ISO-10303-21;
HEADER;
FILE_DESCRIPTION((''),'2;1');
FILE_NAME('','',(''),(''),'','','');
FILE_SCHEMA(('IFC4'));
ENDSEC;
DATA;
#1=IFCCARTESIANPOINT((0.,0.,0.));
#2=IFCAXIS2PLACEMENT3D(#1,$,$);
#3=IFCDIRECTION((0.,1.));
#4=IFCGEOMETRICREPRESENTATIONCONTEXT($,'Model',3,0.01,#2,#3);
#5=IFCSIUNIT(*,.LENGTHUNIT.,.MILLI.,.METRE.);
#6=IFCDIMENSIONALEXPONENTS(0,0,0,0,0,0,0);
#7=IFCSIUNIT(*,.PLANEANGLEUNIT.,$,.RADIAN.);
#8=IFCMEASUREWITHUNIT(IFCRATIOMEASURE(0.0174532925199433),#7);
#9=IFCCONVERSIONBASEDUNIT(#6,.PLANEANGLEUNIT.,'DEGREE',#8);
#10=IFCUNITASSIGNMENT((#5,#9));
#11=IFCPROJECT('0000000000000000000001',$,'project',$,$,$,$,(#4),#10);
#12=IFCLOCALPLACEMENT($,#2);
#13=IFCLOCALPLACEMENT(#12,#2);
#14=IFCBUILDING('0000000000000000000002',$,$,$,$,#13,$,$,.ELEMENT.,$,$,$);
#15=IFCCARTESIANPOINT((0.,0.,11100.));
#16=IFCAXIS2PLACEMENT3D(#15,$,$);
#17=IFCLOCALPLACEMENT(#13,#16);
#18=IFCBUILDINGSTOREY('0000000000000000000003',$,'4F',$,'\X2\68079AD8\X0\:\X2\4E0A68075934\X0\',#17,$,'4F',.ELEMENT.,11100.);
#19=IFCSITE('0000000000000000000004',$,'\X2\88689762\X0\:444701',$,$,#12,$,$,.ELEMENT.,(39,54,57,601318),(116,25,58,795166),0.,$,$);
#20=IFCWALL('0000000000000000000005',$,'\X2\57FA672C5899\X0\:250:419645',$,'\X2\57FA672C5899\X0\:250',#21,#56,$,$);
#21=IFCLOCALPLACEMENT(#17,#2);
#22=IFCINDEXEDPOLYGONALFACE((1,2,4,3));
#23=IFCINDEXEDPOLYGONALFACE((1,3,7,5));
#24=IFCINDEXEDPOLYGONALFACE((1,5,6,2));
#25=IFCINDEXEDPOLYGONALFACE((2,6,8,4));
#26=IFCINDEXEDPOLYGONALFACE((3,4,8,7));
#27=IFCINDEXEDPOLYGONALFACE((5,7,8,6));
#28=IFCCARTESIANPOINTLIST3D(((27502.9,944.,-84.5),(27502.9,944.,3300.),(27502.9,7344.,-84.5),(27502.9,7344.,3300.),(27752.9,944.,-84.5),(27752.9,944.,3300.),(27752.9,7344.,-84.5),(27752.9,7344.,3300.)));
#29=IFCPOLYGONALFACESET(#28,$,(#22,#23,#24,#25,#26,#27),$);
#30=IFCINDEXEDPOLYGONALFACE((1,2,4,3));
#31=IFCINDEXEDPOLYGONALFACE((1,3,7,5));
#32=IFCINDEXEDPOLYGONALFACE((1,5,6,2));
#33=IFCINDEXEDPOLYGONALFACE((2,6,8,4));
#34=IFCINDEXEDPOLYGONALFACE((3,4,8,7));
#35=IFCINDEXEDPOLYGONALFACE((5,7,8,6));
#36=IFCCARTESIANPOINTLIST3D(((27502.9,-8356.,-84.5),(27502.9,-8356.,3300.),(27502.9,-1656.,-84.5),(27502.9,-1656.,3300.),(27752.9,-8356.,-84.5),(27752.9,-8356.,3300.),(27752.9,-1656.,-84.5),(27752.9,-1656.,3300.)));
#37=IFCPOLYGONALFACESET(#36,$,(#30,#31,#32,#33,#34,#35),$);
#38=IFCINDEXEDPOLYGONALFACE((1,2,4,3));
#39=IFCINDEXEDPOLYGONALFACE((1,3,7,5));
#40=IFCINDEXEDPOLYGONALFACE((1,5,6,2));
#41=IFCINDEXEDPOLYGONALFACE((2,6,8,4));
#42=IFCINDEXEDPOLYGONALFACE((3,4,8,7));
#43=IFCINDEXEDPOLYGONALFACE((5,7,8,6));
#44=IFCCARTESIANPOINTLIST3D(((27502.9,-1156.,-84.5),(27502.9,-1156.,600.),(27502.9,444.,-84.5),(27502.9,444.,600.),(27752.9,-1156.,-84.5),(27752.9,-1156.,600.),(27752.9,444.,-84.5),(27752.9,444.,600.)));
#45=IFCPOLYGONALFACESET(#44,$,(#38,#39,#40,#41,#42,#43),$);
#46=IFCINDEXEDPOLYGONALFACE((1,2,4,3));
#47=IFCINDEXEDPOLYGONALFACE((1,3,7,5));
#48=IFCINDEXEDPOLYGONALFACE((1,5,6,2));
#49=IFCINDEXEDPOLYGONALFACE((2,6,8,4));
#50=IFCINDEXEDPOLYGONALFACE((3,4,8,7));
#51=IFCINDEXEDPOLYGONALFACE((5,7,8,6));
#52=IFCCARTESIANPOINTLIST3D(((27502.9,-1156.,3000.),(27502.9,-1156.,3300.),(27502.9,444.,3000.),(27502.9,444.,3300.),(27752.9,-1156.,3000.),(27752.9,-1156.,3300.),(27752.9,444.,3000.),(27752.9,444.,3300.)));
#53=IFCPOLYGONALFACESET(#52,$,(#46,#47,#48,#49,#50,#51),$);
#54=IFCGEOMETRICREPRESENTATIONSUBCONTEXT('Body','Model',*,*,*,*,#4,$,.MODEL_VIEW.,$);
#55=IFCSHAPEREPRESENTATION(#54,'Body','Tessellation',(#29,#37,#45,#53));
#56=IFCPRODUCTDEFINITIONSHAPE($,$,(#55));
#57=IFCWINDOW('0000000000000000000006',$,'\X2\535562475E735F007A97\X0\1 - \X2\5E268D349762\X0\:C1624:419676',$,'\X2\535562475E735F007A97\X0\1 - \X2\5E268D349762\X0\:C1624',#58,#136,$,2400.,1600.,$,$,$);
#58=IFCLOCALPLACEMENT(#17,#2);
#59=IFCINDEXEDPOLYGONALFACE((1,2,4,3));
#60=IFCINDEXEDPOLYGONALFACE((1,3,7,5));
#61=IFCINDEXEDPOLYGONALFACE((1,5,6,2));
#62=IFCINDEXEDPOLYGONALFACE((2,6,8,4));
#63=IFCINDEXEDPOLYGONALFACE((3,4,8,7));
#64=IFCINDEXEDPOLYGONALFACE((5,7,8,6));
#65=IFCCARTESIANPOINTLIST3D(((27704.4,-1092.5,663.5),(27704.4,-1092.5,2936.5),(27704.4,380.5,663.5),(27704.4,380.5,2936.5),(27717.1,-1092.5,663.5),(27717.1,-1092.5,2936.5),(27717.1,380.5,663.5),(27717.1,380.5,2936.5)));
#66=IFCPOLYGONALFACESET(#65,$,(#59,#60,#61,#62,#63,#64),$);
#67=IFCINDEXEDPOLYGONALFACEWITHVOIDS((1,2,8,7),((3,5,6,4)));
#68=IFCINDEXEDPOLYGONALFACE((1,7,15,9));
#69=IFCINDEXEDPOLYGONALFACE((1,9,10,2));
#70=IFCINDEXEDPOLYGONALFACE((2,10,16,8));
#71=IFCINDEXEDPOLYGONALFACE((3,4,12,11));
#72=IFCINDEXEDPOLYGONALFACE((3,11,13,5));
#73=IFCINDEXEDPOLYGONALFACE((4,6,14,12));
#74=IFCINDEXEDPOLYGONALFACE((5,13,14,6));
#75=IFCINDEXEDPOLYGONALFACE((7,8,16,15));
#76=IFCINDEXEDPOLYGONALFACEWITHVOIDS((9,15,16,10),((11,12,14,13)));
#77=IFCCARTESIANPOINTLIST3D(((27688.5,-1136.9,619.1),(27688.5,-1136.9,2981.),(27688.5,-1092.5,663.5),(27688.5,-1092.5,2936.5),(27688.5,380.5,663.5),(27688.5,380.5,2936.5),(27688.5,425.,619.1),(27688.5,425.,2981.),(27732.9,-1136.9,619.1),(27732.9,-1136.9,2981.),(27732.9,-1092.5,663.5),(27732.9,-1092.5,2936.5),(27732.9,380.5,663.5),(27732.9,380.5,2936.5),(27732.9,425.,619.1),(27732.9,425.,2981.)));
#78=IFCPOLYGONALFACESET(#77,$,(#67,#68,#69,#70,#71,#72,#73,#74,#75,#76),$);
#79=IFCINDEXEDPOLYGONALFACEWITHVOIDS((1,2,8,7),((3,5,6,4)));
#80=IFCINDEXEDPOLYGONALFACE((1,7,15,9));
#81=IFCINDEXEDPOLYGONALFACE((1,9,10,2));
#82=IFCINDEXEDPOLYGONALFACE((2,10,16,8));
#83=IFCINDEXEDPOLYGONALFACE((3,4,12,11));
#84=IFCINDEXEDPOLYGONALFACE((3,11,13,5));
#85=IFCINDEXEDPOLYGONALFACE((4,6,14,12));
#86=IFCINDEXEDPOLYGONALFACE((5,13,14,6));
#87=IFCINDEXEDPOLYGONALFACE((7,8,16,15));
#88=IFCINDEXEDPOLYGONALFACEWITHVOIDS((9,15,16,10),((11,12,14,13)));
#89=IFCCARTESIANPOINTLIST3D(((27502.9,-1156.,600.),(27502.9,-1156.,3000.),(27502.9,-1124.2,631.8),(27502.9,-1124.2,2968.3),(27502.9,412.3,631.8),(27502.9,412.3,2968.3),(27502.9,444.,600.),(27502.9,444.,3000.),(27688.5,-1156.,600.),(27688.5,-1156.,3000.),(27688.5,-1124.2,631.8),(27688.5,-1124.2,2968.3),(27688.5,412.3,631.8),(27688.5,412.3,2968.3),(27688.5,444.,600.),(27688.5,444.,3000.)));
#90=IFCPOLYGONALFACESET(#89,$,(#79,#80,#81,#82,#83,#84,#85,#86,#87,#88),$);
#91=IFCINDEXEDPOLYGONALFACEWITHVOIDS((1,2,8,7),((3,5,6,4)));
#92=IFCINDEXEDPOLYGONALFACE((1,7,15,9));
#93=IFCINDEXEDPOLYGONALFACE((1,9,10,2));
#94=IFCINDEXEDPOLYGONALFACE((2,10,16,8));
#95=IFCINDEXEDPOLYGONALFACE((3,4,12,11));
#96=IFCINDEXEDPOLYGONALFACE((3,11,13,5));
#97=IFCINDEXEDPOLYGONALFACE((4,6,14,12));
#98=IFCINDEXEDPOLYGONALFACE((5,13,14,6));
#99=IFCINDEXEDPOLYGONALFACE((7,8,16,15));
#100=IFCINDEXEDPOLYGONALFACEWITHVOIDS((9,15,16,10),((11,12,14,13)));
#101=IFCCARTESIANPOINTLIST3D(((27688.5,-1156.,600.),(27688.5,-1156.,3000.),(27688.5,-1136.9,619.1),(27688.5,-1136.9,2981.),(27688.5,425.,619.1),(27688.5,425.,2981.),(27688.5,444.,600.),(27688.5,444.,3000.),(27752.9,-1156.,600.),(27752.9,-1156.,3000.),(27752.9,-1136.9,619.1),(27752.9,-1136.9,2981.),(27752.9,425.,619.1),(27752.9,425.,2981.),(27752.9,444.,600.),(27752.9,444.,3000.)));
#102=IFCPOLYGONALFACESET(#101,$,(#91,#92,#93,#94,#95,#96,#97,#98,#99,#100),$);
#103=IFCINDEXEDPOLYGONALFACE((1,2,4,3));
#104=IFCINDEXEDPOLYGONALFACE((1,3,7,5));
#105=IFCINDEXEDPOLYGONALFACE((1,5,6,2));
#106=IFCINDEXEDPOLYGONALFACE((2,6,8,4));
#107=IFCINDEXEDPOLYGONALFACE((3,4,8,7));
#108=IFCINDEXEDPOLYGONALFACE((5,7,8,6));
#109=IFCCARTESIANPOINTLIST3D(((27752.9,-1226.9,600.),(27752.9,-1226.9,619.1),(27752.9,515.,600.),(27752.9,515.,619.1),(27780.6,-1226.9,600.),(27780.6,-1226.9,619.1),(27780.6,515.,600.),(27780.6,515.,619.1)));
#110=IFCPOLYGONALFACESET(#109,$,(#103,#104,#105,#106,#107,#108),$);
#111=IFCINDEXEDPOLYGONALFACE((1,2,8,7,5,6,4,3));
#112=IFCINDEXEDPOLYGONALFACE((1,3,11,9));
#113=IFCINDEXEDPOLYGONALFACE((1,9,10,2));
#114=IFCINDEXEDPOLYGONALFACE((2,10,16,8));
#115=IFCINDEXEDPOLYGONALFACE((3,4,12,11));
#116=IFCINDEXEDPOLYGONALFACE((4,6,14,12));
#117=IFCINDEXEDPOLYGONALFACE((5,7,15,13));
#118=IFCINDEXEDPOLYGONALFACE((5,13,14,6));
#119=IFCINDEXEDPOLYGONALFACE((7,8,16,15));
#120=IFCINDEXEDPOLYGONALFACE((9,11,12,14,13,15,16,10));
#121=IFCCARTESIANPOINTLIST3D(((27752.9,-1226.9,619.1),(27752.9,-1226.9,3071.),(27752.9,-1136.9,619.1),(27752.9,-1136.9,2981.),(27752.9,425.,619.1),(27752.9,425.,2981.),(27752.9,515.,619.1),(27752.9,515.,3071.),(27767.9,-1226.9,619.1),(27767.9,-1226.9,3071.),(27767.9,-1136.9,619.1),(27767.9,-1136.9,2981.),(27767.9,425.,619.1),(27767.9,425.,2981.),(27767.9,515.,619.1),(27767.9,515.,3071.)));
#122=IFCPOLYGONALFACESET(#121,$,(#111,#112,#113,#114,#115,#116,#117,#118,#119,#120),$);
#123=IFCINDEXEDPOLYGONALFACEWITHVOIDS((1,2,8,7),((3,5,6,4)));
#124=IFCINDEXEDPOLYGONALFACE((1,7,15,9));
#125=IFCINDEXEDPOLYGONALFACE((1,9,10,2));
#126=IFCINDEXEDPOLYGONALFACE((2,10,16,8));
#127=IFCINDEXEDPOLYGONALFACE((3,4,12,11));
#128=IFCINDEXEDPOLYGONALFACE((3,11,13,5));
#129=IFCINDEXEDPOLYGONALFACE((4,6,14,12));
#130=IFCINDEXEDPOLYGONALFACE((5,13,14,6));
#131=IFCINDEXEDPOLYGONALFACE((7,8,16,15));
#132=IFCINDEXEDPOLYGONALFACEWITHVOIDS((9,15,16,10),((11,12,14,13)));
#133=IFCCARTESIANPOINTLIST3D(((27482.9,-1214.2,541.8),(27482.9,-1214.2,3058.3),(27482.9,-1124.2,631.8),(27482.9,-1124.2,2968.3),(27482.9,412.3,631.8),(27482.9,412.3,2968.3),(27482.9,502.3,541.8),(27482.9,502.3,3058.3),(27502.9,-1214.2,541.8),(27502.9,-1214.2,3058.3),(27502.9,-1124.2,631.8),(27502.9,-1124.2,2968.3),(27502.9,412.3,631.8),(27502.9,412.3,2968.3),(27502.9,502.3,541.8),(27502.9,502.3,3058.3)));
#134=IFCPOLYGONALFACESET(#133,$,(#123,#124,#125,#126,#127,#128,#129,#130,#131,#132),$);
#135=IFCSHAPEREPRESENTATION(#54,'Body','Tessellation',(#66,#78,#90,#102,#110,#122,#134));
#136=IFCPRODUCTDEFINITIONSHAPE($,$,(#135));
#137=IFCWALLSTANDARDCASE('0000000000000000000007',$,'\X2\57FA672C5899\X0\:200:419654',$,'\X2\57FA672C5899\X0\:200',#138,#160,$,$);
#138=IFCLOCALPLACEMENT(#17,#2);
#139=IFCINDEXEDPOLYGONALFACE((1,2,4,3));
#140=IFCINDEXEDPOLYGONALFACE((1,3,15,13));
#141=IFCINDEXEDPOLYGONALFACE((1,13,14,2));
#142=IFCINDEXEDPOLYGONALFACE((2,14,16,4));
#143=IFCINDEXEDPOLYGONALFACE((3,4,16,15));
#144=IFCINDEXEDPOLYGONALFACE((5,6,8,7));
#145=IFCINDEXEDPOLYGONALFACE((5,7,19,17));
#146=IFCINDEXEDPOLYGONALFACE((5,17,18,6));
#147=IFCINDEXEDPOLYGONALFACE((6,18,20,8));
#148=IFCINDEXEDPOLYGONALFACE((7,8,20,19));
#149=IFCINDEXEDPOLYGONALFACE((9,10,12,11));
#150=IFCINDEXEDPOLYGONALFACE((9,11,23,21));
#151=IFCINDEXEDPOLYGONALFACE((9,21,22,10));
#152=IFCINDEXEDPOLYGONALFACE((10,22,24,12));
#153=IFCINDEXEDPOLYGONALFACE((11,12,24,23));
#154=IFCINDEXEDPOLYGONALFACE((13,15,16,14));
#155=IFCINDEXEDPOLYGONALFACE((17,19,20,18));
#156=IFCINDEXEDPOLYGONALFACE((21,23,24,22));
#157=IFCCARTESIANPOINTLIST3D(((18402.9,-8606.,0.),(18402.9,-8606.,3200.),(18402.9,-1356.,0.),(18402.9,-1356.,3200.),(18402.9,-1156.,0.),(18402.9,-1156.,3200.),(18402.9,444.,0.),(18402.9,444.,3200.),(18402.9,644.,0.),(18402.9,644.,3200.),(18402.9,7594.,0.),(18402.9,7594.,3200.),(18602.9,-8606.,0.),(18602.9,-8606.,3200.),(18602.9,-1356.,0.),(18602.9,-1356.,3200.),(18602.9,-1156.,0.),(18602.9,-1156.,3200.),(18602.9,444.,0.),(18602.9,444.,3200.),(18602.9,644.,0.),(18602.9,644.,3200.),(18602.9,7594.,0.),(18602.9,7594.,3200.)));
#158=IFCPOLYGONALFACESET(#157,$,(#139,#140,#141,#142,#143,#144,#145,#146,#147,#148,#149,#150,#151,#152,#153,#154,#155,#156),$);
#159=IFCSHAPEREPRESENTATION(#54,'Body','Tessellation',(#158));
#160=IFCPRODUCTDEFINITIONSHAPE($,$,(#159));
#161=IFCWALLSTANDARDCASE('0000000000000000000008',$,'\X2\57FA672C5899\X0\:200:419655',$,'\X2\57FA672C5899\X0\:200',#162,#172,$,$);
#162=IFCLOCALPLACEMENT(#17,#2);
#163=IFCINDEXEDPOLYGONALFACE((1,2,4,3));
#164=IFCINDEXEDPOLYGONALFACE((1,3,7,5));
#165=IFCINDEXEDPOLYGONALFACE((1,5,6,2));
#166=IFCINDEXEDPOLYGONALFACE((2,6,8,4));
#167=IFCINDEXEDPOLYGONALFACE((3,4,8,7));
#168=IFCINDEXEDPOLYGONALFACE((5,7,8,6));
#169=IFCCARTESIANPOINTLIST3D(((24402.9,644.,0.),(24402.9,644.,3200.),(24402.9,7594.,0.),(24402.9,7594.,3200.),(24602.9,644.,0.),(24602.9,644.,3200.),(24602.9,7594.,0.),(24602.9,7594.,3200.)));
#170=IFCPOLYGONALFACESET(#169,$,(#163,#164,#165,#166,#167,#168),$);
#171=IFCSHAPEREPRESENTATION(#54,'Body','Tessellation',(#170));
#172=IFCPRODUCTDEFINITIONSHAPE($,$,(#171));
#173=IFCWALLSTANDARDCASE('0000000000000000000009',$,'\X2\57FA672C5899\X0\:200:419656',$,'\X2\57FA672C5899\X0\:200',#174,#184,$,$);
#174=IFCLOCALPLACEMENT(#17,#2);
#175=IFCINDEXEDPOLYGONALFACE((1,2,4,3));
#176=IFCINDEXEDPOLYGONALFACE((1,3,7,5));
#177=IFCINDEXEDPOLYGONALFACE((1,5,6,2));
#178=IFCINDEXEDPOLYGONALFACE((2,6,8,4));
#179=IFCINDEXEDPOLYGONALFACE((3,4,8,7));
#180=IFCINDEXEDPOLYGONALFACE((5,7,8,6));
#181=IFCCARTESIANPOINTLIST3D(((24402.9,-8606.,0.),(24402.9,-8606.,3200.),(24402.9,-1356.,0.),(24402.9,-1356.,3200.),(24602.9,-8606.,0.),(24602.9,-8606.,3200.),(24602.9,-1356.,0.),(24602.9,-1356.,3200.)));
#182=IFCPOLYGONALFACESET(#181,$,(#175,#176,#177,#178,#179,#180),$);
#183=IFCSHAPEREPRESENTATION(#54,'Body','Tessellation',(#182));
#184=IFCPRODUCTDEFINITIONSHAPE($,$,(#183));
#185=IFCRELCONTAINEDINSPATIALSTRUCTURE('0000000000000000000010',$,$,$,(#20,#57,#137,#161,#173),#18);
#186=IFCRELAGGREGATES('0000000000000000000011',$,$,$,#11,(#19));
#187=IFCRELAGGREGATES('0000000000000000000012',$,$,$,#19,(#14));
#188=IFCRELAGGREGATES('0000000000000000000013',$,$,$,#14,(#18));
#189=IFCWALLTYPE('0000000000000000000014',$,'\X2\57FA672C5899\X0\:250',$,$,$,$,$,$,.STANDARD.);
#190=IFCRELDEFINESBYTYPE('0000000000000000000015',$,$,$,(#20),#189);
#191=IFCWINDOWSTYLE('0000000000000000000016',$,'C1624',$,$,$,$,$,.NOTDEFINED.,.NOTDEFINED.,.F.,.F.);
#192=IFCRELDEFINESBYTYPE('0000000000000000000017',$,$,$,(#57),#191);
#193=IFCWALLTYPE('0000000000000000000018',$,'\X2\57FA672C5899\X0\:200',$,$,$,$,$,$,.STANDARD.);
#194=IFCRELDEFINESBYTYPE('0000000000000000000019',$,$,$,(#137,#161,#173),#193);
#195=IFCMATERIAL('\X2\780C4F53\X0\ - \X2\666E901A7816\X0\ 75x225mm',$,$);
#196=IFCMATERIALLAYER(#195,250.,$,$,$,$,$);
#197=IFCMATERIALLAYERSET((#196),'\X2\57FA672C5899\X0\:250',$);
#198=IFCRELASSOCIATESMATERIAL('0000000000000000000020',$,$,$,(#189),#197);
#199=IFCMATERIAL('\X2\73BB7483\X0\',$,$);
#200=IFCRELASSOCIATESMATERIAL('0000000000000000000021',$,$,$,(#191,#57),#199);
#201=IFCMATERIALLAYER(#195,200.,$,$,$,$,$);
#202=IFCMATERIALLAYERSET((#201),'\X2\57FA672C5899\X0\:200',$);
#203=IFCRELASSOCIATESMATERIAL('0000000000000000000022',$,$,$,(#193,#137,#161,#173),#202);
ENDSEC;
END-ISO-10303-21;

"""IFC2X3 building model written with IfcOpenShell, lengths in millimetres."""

from ifc_helpers import new_model, entity, si_unit, converted_unit, direction, frame, frame_2d, origin, origin_2d_with_axis, place, context, subcontext, project, spatial, polyline, rectangle, outline, extrude, source, transform, mapped, material, layer, layer_set, layer_usage, type_object, type_shapes, element, fill, save


model = new_model("IFC2X3")

# Units and contexts
model_context = context("Model", 3, precision=0.01, world=origin(), true_north=direction((0.0, 1.0)))
body_context = subcontext(model_context, "Body", "Model", "MODEL_VIEW")
ifc_project = project(units=[si_unit("LENGTHUNIT", "METRE", prefix="MILLI"), converted_unit("PLANEANGLEUNIT", "DEGREE", entity("IfcRatioMeasure", 0.0174532925199433), si_unit("PLANEANGLEUNIT", "RADIAN"), dimensions=[0, 0, 0, 0, 0, 0, 0])], contexts=[model_context])

# Site, building, storey
site_placement = place(None, origin())
site = spatial("IfcSite", under=ifc_project, at=site_placement, Name="表面:444701", CompositionType="ELEMENT", RefLatitude=(39, 54, 57, 601318), RefLongitude=(116, 25, 58, 795166), RefElevation=0.0)
building_placement = place(site_placement, origin())
building = spatial("IfcBuilding", under=site, at=building_placement, CompositionType="ELEMENT")
storey_placement = place(building_placement, frame((0.0, 0.0, 11100.0)))
storey = spatial("IfcBuildingStorey", under=building, at=storey_placement, Name="4F", ObjectType="标高:上标头", LongName="4F", CompositionType="ELEMENT", Elevation=11100.0)

# Wall, opening, window
ifc_material_1 = material(Name="砌体 - 普通砖 75x225mm")
ifc_layer_1 = layer(ifc_material_1, 250.0)
ifc_layer_set_1 = layer_set([ifc_layer_1], Name="基本墙:250")
wall_type_1 = type_object("IfcWallType", Name="基本墙:250", PredefinedType="STANDARD", material=ifc_layer_set_1)
wall_1_placement = place(storey_placement, frame((27627.9, 7344.0, -84.5), z_axis=(0.0, 0.0, 1.0), x_axis=(0.0, -1.0, 0.0)))
wall_1 = element("IfcWall", 1, at=wall_1_placement, inside=storey, type_object=wall_type_1, Name="基本墙:250:419645", ObjectType="基本墙:250", context=body_context, shape_type="SweptSolid", body=[
    extrude(rectangle(XDim=6400.0, YDim=250.0, at=frame_2d((0.0, 0.0), x_axis=(1.0, 0.0))), frame((3200.0, 0.0, 0.0), z_axis=(0.0, 0.0, 1.0), x_axis=(-1.0, 0.0, 0.0)), (0.0, 0.0, 1.0), 3384.5),
    extrude(rectangle(XDim=6700.0, YDim=250.0, at=origin_2d_with_axis()), frame((12350.0, 0.0, 0.0), z_axis=(0.0, 0.0, 1.0), x_axis=(-1.0, 0.0, 0.0)), (0.0, 0.0, 1.0), 3384.5),
    extrude(rectangle(XDim=1600.0, YDim=250.0, at=frame_2d((0.0, 0.0), x_axis=(1.0, 0.0))), frame((7700.0, 0.0, 0.0), z_axis=(0.0, 0.0, 1.0), x_axis=(-1.0, 0.0, 0.0)), (0.0, 0.0, 1.0), 684.5),
    extrude(rectangle(XDim=250.0, YDim=1600.0, at=frame_2d((0.0, 0.0), x_axis=(1.0, 0.0))), frame((7700.0, 0.0, 3084.5), z_axis=(0.0, 0.0, 1.0), x_axis=(0.0, 1.0, 0.0)), (0.0, 0.0, 1.0), 300.0),
])
opening_1_placement = place(wall_1_placement, frame((6900.0, -125.0, 684.5)))
opening_1 = element("IfcOpeningElement", 2, at=opening_1_placement, cuts=wall_1, ObjectType="Opening", context=body_context, shape_type="SweptSolid", body=[
    extrude(rectangle(XDim=2400.0, YDim=1600.0, at=frame_2d((1200.0, 800.0), x_axis=(-1.0, 0.0))), frame((0.0, 0.0, 0.0), z_axis=(0.0, 1.0, 0.0), x_axis=(0.0, 0.0, 1.0)), (0.0, 0.0, 1.0), 250.0),
])
ifc_material_2 = material(Name="玻璃")
window_style_1 = type_object("IfcWindowStyle", Name="C1624", ConstructionType="NOTDEFINED", OperationType="NOTDEFINED", ParameterTakesPrecedence=False, Sizeable=False, material=ifc_material_2)
shared_shape_1 = source(origin(), body_context, "Body", "SweptSolid", [
    extrude(rectangle(XDim=12.7, YDim=1473.0, at=origin_2d_with_axis()), frame((800.0, 207.8, 63.5), z_axis=(0.0, 0.0, 1.0), x_axis=(0.0, 1.0, 0.0)), (0.0, 0.0, 1.0), 2273.0),
    extrude(outline(polyline([(-780.9, -1181.0), (780.9, -1181.0), (780.9, 1181.0), (-780.9, 1181.0), (-780.9, -1181.0)]), holes=[polyline([(-736.5, -1136.5), (-736.5, 1136.5), (736.5, 1136.5), (736.5, -1136.5), (-736.5, -1136.5)])]), frame((800.0, 185.6, 1200.0), z_axis=(0.0, 1.0, 0.0), x_axis=(1.0, 0.0, 0.0)), (0.0, 0.0, 1.0), 44.5),
    extrude(outline(polyline([(-800.0, -1200.0), (800.0, -1200.0), (800.0, 1200.0), (-800.0, 1200.0), (-800.0, -1200.0)]), holes=[polyline([(-768.2, -1168.2), (-768.2, 1168.2), (768.2, 1168.2), (768.2, -1168.2), (-768.2, -1168.2)])]), frame((800.0, 0.0, 1200.0), z_axis=(0.0, 1.0, 0.0), x_axis=(1.0, 0.0, 0.0)), (0.0, 0.0, 1.0), 185.6),
    extrude(outline(polyline([(-1200.0, -800.0), (1200.0, -800.0), (1200.0, 800.0), (-1200.0, 800.0), (-1200.0, -800.0)]), holes=[polyline([(-1181.0, -780.9), (-1181.0, 781.0), (1181.0, 781.0), (1181.0, -780.9), (-1181.0, -780.9)])]), frame((800.0, 185.6, 1200.0), z_axis=(0.0, 1.0, 0.0), x_axis=(0.0, 0.0, -1.0)), (0.0, 0.0, 1.0), 64.5),
    extrude(rectangle(XDim=27.7, YDim=1741.9, at=frame_2d((0.0, 0.0), x_axis=(1.0, 0.0))), frame((800.0, 263.9, 0.0), z_axis=(0.0, 0.0, 1.0), x_axis=(0.0, -1.0, 0.0)), (0.0, 0.0, 1.0), 19.0),
    extrude(outline(polyline([(-1158.5, 780.9), (1203.5, 780.9), (1203.5, 870.9), (-1248.5, 870.9), (-1248.5, -870.9), (1203.5, -870.9), (1203.5, -780.9), (-1158.5, -780.9), (-1158.5, 780.9)])), frame((800.0, 250.0, 1222.5), z_axis=(0.0, 1.0, 0.0), x_axis=(0.0, 0.0, -1.0)), (0.0, 0.0, 1.0), 15.0),
    extrude(outline(polyline([(-1258.3, -858.2), (1258.3, -858.2), (1258.3, 858.2), (-1258.3, 858.2), (-1258.3, -858.2)]), holes=[polyline([(-1168.3, -768.2), (-1168.3, 768.3), (1168.2, 768.3), (1168.2, -768.2), (-1168.3, -768.2)])]), frame((800.0, -20.0, 1200.0), z_axis=(0.0, 1.0, 0.0), x_axis=(0.0, 0.0, -1.0)), (0.0, 0.0, 1.0), 20.0),
])
type_shapes(window_style_1, [shared_shape_1])
window_1_placement = place(opening_1_placement, origin())
window_1 = element("IfcWindow", 3, at=window_1_placement, inside=storey, type_object=window_style_1, material=ifc_material_2, Name="单扇平开窗1 - 带贴面:C1624:419676", ObjectType="单扇平开窗1 - 带贴面:C1624", OverallHeight=2400.0, OverallWidth=1600.0, context=body_context, shape_type="MappedRepresentation", body=[
    mapped(shared_shape_1, transform((0.0, 0.0, 0.0), scale=1.0)),
])
fill(opening_1, window_1)

# Wall, openings
ifc_layer_2 = layer(ifc_material_1, 200.0)
ifc_layer_set_2 = layer_set([ifc_layer_2], Name="基本墙:200")
ifc_layer_usage_1 = layer_usage(ifc_layer_set_2, "AXIS2", "NEGATIVE", 100.0)
wall_type_2 = type_object("IfcWallType", Name="基本墙:200", PredefinedType="STANDARD", material=ifc_layer_set_2)
wall_2_placement = place(storey_placement, frame((18502.9, -8606.0, 0.0), z_axis=(0.0, 0.0, 1.0), x_axis=(0.0, 1.0, 0.0)))
wall_2 = element("IfcWallStandardCase", 4, at=wall_2_placement, inside=storey, type_object=wall_type_2, material=ifc_layer_usage_1, Name="基本墙:200:419654", ObjectType="基本墙:200", context=body_context, shape_type="SweptSolid", body=[
    extrude(rectangle(XDim=16200.0, YDim=200.0, at=frame_2d((8100.0, 0.0), x_axis=(-1.0, 0.0))), origin(), (0.0, 0.0, 1.0), 3200.0),
])
opening_2_placement = place(storey_placement, frame((18502.9, -8606.0, 0.0), z_axis=(0.0, 0.0, 1.0), x_axis=(0.0, 1.0, 0.0)))
element("IfcOpeningElement", 5, at=opening_2_placement, cuts=wall_2, ObjectType="Opening", context=body_context, shape_type="SweptSolid", body=[
    extrude(rectangle(XDim=3200.0, YDim=200.0, at=frame_2d((0.0, 0.0), x_axis=(1.0, 0.0))), frame((7250.0, 0.0, 1600.0), z_axis=(1.0, 0.0, 0.0), x_axis=(0.0, 0.0, -1.0)), (0.0, 0.0, 1.0), 200.0),
])
opening_3_placement = place(storey_placement, frame((18502.9, -8606.0, 0.0), z_axis=(0.0, 0.0, 1.0), x_axis=(0.0, 1.0, 0.0)))
element("IfcOpeningElement", 6, at=opening_3_placement, cuts=wall_2, ObjectType="Opening", context=body_context, shape_type="SweptSolid", body=[
    extrude(rectangle(XDim=3200.0, YDim=200.0, at=frame_2d((0.0, 0.0), x_axis=(1.0, 0.0))), frame((9050.0, 0.0, 1600.0), z_axis=(1.0, 0.0, 0.0), x_axis=(0.0, 0.0, -1.0)), (0.0, 0.0, 1.0), 200.0),
])

# Walls
ifc_layer_usage_2 = layer_usage(ifc_layer_set_2, "AXIS2", "NEGATIVE", 100.0)
wall_3_placement = place(storey_placement, frame((24502.9, 7594.0, 0.0), z_axis=(0.0, 0.0, 1.0), x_axis=(0.0, -1.0, 0.0)))
element("IfcWallStandardCase", 7, at=wall_3_placement, inside=storey, type_object=wall_type_2, material=ifc_layer_usage_2, Name="基本墙:200:419655", ObjectType="基本墙:200", context=body_context, shape_type="SweptSolid", body=[
    extrude(rectangle(XDim=6950.0, YDim=200.0, at=frame_2d((3475.0, 0.0), x_axis=(-1.0, 0.0))), origin(), (0.0, 0.0, 1.0), 3200.0),
])
ifc_layer_usage_3 = layer_usage(ifc_layer_set_2, "AXIS2", "NEGATIVE", 100.0)
wall_4_placement = place(storey_placement, frame((24502.9, -1356.0, 0.0), z_axis=(0.0, 0.0, 1.0), x_axis=(0.0, -1.0, 0.0)))
element("IfcWallStandardCase", 8, at=wall_4_placement, inside=storey, type_object=wall_type_2, material=ifc_layer_usage_3, Name="基本墙:200:419656", ObjectType="基本墙:200", context=body_context, shape_type="SweptSolid", body=[
    extrude(rectangle(XDim=7250.0, YDim=200.0, at=frame_2d((3625.0, 0.0), x_axis=(-1.0, 0.0))), origin(), (0.0, 0.0, 1.0), 3200.0),
])

save(model, "model.ifc")
